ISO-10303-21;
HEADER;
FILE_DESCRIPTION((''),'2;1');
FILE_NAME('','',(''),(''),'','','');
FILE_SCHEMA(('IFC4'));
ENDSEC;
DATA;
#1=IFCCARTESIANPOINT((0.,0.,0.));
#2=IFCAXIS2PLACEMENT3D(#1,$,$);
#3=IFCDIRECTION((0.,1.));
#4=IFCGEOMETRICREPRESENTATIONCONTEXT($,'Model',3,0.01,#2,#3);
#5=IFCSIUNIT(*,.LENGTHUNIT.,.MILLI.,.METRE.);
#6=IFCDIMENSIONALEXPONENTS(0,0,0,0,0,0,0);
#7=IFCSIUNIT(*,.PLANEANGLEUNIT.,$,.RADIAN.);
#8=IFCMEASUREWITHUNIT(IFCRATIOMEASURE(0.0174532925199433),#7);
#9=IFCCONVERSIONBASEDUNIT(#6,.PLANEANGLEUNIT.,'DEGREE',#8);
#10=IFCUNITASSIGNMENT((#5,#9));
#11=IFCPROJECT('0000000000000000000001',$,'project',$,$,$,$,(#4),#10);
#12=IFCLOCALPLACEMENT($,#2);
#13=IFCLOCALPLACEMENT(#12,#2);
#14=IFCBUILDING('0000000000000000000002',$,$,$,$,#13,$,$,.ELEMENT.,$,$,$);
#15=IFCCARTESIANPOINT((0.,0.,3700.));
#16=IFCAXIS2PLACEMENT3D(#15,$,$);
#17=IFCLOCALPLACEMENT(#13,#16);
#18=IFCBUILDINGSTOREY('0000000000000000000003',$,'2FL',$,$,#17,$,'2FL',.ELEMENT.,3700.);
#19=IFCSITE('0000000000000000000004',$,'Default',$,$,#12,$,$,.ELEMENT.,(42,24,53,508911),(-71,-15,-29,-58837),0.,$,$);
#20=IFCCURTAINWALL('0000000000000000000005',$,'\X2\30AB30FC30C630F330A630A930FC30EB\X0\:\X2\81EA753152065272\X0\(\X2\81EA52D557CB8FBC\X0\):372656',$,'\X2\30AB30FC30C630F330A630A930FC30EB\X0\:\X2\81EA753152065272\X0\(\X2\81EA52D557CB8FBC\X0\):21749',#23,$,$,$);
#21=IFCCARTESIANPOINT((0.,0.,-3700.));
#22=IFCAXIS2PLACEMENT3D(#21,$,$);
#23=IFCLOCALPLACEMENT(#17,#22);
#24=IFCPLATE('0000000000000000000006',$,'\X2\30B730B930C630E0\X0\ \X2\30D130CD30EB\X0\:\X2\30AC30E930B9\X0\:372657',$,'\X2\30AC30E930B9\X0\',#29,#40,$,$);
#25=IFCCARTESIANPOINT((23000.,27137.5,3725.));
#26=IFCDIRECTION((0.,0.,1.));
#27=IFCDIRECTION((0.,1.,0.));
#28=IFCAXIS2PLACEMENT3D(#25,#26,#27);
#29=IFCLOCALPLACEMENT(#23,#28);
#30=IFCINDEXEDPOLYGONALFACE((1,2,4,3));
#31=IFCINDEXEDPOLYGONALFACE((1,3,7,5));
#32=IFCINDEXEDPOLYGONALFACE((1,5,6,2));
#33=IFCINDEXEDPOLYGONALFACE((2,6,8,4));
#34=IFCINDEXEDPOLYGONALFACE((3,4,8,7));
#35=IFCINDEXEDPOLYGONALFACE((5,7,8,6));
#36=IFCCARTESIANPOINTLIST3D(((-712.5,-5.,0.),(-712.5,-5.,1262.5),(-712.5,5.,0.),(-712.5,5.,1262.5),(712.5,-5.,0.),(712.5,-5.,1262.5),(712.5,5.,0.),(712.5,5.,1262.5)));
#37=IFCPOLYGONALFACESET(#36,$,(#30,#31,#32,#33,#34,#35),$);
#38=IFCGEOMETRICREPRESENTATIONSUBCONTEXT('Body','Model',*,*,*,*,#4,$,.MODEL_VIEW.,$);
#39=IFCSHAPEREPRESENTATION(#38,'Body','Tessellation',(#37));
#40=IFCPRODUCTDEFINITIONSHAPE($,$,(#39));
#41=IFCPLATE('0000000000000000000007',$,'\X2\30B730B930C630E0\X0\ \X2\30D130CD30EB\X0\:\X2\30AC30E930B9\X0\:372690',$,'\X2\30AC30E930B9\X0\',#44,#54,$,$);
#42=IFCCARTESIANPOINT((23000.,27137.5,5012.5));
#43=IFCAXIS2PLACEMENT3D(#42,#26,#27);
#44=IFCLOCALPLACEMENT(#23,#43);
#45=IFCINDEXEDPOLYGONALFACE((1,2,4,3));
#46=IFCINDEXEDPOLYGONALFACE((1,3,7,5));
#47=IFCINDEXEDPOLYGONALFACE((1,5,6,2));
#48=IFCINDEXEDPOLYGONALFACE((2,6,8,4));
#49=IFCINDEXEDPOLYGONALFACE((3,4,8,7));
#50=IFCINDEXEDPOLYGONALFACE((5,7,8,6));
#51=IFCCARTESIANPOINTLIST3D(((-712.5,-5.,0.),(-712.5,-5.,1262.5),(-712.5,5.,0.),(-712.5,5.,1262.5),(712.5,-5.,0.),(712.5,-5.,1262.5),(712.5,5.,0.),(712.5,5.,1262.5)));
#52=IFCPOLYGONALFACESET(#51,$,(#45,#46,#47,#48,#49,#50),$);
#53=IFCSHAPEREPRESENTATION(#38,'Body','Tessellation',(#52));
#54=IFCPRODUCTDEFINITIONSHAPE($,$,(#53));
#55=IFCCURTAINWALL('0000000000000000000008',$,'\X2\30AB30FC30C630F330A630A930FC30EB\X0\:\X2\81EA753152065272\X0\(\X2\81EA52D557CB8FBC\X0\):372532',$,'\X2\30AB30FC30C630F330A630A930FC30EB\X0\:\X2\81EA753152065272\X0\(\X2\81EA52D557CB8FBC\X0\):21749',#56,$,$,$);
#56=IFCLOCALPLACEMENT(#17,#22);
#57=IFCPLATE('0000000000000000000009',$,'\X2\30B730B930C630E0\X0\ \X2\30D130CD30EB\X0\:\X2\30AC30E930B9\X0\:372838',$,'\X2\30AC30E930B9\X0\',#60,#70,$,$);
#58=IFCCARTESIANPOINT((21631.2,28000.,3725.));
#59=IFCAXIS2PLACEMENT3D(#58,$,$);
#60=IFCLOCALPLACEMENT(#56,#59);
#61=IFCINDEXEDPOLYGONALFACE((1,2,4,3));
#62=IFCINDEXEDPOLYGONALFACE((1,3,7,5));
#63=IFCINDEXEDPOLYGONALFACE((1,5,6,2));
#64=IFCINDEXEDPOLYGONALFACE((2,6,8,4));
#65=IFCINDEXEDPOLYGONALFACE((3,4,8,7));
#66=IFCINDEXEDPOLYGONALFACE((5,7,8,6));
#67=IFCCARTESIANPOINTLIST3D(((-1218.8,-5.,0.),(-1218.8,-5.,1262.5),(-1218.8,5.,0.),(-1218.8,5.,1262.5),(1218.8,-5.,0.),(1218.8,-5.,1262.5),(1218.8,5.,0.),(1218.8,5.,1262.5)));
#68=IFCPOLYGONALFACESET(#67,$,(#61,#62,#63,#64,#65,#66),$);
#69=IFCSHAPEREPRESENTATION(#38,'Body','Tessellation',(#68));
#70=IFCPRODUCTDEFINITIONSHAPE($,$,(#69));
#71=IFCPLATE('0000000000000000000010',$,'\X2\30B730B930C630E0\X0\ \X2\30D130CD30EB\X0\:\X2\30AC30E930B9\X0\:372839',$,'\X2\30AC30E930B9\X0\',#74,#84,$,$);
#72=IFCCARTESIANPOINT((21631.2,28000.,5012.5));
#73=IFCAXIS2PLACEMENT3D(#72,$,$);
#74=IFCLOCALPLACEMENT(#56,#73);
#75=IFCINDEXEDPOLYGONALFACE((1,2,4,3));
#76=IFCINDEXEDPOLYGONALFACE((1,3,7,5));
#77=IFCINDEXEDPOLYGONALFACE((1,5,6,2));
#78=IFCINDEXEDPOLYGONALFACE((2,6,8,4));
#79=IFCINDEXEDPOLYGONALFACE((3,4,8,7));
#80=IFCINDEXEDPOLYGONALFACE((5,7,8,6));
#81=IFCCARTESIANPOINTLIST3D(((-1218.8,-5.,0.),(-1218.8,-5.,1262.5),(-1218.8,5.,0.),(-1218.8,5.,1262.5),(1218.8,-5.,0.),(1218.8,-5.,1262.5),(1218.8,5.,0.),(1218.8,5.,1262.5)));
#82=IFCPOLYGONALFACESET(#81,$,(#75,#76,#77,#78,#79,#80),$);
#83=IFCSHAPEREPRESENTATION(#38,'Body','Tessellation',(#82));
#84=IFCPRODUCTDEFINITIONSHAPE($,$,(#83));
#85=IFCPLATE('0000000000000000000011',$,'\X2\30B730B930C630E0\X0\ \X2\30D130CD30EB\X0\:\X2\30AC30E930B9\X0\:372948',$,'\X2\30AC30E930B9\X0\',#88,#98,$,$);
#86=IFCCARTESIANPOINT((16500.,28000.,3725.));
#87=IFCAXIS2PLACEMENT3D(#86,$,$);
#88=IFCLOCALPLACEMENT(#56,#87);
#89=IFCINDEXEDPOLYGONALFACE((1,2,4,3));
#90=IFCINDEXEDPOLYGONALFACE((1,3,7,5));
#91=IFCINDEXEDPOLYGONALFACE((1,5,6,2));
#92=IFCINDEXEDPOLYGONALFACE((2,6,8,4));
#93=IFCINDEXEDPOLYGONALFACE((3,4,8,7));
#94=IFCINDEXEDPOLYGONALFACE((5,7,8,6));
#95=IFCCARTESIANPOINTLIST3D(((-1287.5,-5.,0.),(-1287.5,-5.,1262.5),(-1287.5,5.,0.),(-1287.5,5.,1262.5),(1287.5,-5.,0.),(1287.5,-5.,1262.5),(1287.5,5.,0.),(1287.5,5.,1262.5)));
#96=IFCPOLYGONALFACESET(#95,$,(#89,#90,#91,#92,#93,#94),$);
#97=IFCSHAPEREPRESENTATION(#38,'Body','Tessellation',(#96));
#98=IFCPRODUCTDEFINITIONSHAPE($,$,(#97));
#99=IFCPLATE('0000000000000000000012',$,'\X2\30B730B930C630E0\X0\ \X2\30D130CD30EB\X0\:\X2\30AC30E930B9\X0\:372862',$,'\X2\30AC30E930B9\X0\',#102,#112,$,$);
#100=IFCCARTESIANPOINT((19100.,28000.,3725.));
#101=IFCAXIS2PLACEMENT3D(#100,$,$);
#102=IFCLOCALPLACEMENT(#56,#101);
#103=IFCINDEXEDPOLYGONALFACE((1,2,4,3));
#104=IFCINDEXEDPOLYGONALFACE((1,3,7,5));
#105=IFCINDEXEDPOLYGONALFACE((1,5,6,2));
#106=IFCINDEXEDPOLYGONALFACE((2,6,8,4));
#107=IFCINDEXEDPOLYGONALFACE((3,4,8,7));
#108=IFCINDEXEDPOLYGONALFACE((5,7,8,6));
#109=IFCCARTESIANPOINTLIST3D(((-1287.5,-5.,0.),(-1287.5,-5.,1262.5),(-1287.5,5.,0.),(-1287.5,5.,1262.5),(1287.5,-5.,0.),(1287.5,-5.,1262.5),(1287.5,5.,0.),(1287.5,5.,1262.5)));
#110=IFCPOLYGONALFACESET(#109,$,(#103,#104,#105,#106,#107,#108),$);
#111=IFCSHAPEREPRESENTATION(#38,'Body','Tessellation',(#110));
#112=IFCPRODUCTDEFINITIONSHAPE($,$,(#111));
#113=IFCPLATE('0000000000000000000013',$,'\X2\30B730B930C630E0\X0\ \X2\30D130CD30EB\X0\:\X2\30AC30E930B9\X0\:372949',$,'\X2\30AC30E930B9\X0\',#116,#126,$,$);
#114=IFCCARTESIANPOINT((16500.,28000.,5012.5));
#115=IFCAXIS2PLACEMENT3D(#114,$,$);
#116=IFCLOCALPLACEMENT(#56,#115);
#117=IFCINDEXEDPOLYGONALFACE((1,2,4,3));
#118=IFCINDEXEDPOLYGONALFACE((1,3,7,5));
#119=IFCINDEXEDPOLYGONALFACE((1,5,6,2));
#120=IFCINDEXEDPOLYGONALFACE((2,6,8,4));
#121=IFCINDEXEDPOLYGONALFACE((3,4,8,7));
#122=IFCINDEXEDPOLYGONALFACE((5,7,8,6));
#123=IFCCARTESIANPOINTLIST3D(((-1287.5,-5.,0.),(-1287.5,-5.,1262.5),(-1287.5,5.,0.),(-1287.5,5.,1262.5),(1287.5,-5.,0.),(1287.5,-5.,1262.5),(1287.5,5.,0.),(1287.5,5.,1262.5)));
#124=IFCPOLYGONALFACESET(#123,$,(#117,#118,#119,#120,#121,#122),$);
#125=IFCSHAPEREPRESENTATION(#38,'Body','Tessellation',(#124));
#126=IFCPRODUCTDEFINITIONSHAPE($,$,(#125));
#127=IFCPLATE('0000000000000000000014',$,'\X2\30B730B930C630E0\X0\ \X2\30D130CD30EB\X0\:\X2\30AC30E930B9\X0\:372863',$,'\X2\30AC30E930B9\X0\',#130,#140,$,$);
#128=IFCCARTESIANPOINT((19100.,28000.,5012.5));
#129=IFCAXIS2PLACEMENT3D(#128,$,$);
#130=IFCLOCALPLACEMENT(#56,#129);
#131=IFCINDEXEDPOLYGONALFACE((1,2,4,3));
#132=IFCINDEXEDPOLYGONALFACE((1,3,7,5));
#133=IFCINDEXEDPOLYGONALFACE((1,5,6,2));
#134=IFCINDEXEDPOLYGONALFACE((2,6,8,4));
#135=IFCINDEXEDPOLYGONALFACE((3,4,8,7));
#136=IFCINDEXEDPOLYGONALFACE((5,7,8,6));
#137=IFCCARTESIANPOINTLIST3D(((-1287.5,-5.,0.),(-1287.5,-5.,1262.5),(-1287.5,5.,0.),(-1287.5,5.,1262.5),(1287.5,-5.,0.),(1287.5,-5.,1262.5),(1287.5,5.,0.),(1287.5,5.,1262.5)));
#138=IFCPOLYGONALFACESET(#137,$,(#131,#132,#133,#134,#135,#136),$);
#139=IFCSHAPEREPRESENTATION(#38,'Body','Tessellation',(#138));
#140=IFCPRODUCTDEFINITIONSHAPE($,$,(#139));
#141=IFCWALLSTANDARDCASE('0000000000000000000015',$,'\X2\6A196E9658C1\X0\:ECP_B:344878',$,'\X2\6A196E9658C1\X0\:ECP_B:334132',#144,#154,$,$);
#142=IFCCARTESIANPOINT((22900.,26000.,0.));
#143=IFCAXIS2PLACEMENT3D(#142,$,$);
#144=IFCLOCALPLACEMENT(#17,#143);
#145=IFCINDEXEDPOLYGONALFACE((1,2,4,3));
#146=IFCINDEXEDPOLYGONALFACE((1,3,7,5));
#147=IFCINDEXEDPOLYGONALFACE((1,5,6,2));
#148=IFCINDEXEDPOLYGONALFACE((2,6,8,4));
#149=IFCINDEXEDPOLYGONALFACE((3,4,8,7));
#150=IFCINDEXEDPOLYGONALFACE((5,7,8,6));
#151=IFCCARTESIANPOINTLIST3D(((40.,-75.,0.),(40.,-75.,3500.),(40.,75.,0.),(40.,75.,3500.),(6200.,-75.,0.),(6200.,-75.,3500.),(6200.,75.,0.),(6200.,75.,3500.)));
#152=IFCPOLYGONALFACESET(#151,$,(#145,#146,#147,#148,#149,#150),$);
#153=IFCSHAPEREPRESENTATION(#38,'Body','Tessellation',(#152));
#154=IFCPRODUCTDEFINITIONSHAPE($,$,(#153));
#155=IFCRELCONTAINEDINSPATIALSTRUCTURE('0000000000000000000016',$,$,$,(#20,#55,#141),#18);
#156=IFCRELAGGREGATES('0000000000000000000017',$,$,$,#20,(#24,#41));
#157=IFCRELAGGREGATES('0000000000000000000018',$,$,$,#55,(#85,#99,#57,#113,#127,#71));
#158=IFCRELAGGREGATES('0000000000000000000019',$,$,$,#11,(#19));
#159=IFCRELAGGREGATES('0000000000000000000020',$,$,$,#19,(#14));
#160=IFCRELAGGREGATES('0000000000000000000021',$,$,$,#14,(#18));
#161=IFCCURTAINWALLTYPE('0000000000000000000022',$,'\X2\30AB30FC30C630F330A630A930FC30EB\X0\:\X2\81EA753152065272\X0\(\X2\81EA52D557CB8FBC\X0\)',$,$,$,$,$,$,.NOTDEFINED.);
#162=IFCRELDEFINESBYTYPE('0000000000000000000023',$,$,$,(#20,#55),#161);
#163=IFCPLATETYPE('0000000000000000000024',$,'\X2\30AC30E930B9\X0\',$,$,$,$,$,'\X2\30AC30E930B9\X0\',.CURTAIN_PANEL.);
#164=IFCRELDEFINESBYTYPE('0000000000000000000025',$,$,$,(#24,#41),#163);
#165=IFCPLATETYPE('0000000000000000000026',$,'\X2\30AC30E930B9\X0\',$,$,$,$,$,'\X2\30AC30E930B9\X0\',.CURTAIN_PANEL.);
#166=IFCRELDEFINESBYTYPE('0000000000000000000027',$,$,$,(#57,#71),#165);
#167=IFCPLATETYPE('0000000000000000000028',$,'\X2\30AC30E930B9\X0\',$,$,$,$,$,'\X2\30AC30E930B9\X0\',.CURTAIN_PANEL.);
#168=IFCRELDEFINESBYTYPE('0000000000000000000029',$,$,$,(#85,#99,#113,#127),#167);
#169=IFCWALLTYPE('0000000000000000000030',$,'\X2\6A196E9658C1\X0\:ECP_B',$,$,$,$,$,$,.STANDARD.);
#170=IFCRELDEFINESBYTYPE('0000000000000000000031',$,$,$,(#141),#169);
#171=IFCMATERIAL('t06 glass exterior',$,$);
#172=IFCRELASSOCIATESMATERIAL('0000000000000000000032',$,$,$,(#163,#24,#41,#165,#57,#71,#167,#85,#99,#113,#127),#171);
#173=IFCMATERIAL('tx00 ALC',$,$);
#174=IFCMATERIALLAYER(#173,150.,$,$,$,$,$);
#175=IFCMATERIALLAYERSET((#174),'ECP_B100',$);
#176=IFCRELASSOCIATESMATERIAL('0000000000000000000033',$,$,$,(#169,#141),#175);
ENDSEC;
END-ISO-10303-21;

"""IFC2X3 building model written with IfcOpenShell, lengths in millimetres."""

from ifc_helpers import new_model, entity, si_unit, converted_unit, direction, frame, frame_2d, origin, origin_2d_with_axis, place, context, subcontext, project, spatial, rectangle, extrude, source, transform, mapped, material, layer, layer_set, layer_usage, type_object, type_shapes, element, aggregate, save


model = new_model("IFC2X3")

# Units and contexts
model_context = context("Model", 3, precision=0.01, world=origin(), true_north=direction((0.0, 1.0)))
body_context = subcontext(model_context, "Body", "Model", "MODEL_VIEW")
ifc_project = project(units=[si_unit("LENGTHUNIT", "METRE", prefix="MILLI"), converted_unit("PLANEANGLEUNIT", "DEGREE", entity("IfcRatioMeasure", 0.0174532925199433), si_unit("PLANEANGLEUNIT", "RADIAN"), dimensions=[0, 0, 0, 0, 0, 0, 0])], contexts=[model_context])

# Site, building, storey
site_placement = place(None, origin())
site = spatial("IfcSite", under=ifc_project, at=site_placement, Name="Default", CompositionType="ELEMENT", RefLatitude=(42, 24, 53, 508911), RefLongitude=(-71, -15, -29, -58837), RefElevation=0.0)
building_placement = place(site_placement, origin())
building = spatial("IfcBuilding", under=site, at=building_placement, CompositionType="ELEMENT")
storey_placement = place(building_placement, frame((0.0, 0.0, 3700.0)))
storey = spatial("IfcBuildingStorey", under=building, at=storey_placement, Name="2FL", LongName="2FL", CompositionType="ELEMENT", Elevation=3700.0)

# Curtain walls, plates
curtain_wall_type = type_object("IfcCurtainWallType", Name="カーテンウォール:自由分割(自動埋込)", PredefinedType="NOTDEFINED")
curtain_wall_1_placement = place(storey_placement, frame((0.0, 0.0, -3700.0)))
curtain_wall_1 = element("IfcCurtainWall", 1, at=curtain_wall_1_placement, inside=storey, type_object=curtain_wall_type, Name="カーテンウォール:自由分割(自動埋込):372656", ObjectType="カーテンウォール:自由分割(自動埋込):21749")
ifc_material_1 = material(Name="t06 glass exterior")
plate_type_1 = type_object("IfcPlateType", Name="ガラス", ElementType="ガラス", PredefinedType="CURTAIN_PANEL", material=ifc_material_1)
shared_shape_1 = source(origin(), body_context, "Body", "SweptSolid", [
    extrude(rectangle(XDim=10.0, YDim=1425.0, at=origin_2d_with_axis()), frame((0.0, 0.0, 0.0), z_axis=(0.0, 0.0, 1.0), x_axis=(0.0, 1.0, 0.0)), (0.0, 0.0, 1.0), 1262.5),
])
type_shapes(plate_type_1, [shared_shape_1])
plate_1_placement = place(curtain_wall_1_placement, frame((23000.0, 27137.5, 3725.0), z_axis=(0.0, 0.0, 1.0), x_axis=(0.0, 1.0, 0.0)))
plate_1 = element("IfcPlate", 2, at=plate_1_placement, type_object=plate_type_1, material=ifc_material_1, Name="システム パネル:ガラス:372657", ObjectType="ガラス", context=body_context, shape_type="MappedRepresentation", body=[
    mapped(shared_shape_1, transform((0.0, 0.0, 0.0), scale=1.0)),
])
plate_2_placement = place(curtain_wall_1_placement, frame((23000.0, 27137.5, 5012.5), z_axis=(0.0, 0.0, 1.0), x_axis=(0.0, 1.0, 0.0)))
plate_2 = element("IfcPlate", 3, at=plate_2_placement, type_object=plate_type_1, material=ifc_material_1, Name="システム パネル:ガラス:372690", ObjectType="ガラス", context=body_context, shape_type="MappedRepresentation", body=[
    mapped(shared_shape_1, transform((0.0, 0.0, 0.0), scale=1.0)),
])
aggregate(curtain_wall_1, [plate_1, plate_2])
curtain_wall_2_placement = place(storey_placement, frame((0.0, 0.0, -3700.0)))
curtain_wall_2 = element("IfcCurtainWall", 4, at=curtain_wall_2_placement, inside=storey, type_object=curtain_wall_type, Name="カーテンウォール:自由分割(自動埋込):372532", ObjectType="カーテンウォール:自由分割(自動埋込):21749")
plate_type_2 = type_object("IfcPlateType", Name="ガラス", ElementType="ガラス", PredefinedType="CURTAIN_PANEL", material=ifc_material_1)
shared_shape_2 = source(origin(), body_context, "Body", "SweptSolid", [
    extrude(rectangle(XDim=10.0, YDim=2437.5, at=origin_2d_with_axis()), frame((0.0, 0.0, 0.0), z_axis=(0.0, 0.0, 1.0), x_axis=(0.0, 1.0, 0.0)), (0.0, 0.0, 1.0), 1262.5),
])
type_shapes(plate_type_2, [shared_shape_2])
plate_3_placement = place(curtain_wall_2_placement, frame((21631.2, 28000.0, 3725.0)))
plate_3 = element("IfcPlate", 5, at=plate_3_placement, type_object=plate_type_2, material=ifc_material_1, Name="システム パネル:ガラス:372838", ObjectType="ガラス", context=body_context, shape_type="MappedRepresentation", body=[
    mapped(shared_shape_2, transform((0.0, 0.0, 0.0), scale=1.0)),
])
plate_4_placement = place(curtain_wall_2_placement, frame((21631.2, 28000.0, 5012.5)))
plate_4 = element("IfcPlate", 6, at=plate_4_placement, type_object=plate_type_2, material=ifc_material_1, Name="システム パネル:ガラス:372839", ObjectType="ガラス", context=body_context, shape_type="MappedRepresentation", body=[
    mapped(shared_shape_2, transform((0.0, 0.0, 0.0), scale=1.0)),
])
plate_type_3 = type_object("IfcPlateType", Name="ガラス", ElementType="ガラス", PredefinedType="CURTAIN_PANEL", material=ifc_material_1)
shared_shape_3 = source(origin(), body_context, "Body", "SweptSolid", [
    extrude(rectangle(XDim=10.0, YDim=2575.0, at=origin_2d_with_axis()), frame((0.0, 0.0, 0.0), z_axis=(0.0, 0.0, 1.0), x_axis=(0.0, 1.0, 0.0)), (0.0, 0.0, 1.0), 1262.5),
])
type_shapes(plate_type_3, [shared_shape_3])
plate_5_placement = place(curtain_wall_2_placement, frame((16500.0, 28000.0, 3725.0)))
plate_5 = element("IfcPlate", 7, at=plate_5_placement, type_object=plate_type_3, material=ifc_material_1, Name="システム パネル:ガラス:372948", ObjectType="ガラス", context=body_context, shape_type="MappedRepresentation", body=[
    mapped(shared_shape_3, transform((0.0, 0.0, 0.0), scale=1.0)),
])
plate_6_placement = place(curtain_wall_2_placement, frame((19100.0, 28000.0, 3725.0)))
plate_6 = element("IfcPlate", 8, at=plate_6_placement, type_object=plate_type_3, material=ifc_material_1, Name="システム パネル:ガラス:372862", ObjectType="ガラス", context=body_context, shape_type="MappedRepresentation", body=[
    mapped(shared_shape_3, transform((0.0, 0.0, 0.0), scale=1.0)),
])
plate_7_placement = place(curtain_wall_2_placement, frame((16500.0, 28000.0, 5012.5)))
plate_7 = element("IfcPlate", 9, at=plate_7_placement, type_object=plate_type_3, material=ifc_material_1, Name="システム パネル:ガラス:372949", ObjectType="ガラス", context=body_context, shape_type="MappedRepresentation", body=[
    mapped(shared_shape_3, transform((0.0, 0.0, 0.0), scale=1.0)),
])
plate_8_placement = place(curtain_wall_2_placement, frame((19100.0, 28000.0, 5012.5)))
plate_8 = element("IfcPlate", 10, at=plate_8_placement, type_object=plate_type_3, material=ifc_material_1, Name="システム パネル:ガラス:372863", ObjectType="ガラス", context=body_context, shape_type="MappedRepresentation", body=[
    mapped(shared_shape_3, transform((0.0, 0.0, 0.0), scale=1.0)),
])
aggregate(curtain_wall_2, [plate_5, plate_6, plate_3, plate_7, plate_8, plate_4])

# Shared definitions
ifc_material_2 = material(Name="tx00 ALC")

# Wall
ifc_layer_1 = layer(ifc_material_2, 150.0)
ifc_layer_set_1 = layer_set([ifc_layer_1], Name="ECP_B100")
ifc_layer_usage_1 = layer_usage(ifc_layer_set_1, "AXIS2", "NEGATIVE", 75.0)
wall_type_1 = type_object("IfcWallType", Name="標準壁:ECP_B", PredefinedType="STANDARD", material=ifc_layer_set_1)
wall_1_placement = place(storey_placement, frame((22900.0, 26000.0, 0.0)))
element("IfcWallStandardCase", 11, at=wall_1_placement, inside=storey, type_object=wall_type_1, material=ifc_layer_usage_1, Name="標準壁:ECP_B:344878", ObjectType="標準壁:ECP_B:334132", context=body_context, shape_type="SweptSolid", body=[
    extrude(rectangle(XDim=6160.0, YDim=150.0, at=frame_2d((3120.0, 0.0), x_axis=(-1.0, 0.0))), origin(), (0.0, 0.0, 1.0), 3500.0),
])

save(model, "model.ifc")
